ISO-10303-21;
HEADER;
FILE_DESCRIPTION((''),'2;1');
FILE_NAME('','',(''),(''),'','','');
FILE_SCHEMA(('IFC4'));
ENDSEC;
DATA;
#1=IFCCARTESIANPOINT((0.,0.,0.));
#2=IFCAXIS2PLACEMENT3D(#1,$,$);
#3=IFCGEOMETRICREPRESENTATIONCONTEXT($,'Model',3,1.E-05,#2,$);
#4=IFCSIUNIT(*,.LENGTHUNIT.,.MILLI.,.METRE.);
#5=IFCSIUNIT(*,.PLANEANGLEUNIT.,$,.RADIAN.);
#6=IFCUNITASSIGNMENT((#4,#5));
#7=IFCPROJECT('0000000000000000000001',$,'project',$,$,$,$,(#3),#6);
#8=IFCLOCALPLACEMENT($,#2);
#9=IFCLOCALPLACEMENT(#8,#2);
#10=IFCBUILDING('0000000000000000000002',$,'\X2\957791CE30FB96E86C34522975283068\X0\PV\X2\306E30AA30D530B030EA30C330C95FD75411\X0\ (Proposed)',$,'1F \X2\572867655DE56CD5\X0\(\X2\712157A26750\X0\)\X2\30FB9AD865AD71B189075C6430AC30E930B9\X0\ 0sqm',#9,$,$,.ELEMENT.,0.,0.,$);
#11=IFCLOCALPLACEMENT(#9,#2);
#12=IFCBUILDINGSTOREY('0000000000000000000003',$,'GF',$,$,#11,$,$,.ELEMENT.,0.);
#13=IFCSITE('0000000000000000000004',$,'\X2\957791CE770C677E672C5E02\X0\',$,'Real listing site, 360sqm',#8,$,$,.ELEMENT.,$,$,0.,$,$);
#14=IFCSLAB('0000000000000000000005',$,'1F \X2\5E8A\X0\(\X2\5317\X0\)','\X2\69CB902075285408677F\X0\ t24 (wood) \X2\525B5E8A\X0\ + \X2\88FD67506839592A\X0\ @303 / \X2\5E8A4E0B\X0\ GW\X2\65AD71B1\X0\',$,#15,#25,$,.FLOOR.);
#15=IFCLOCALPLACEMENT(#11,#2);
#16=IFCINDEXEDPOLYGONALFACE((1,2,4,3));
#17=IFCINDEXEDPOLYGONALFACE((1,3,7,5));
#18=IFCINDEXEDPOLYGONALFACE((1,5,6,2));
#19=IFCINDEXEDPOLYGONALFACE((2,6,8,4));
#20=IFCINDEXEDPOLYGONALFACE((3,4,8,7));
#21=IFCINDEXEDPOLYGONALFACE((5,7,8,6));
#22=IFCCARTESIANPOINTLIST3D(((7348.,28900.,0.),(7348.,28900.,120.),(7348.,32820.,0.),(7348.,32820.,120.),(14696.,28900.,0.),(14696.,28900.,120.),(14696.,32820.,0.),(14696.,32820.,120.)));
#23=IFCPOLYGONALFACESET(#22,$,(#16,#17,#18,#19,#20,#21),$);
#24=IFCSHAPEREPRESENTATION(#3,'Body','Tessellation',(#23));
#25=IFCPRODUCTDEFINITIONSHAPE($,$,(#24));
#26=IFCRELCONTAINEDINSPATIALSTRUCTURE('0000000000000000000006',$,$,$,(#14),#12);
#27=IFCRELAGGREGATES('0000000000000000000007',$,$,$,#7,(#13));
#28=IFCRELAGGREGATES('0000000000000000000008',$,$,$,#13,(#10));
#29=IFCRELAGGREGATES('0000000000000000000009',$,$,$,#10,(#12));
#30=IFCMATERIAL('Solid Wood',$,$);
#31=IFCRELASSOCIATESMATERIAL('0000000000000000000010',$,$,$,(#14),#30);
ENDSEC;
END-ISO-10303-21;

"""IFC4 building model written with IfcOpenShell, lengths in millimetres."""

from ifc_helpers import new_model, si_unit, frame, frame_2d, origin, place, context, project, spatial, rectangle, extrude, material, element, save


model = new_model("IFC4")

# Units and contexts
model_context = context("Model", 3, precision=1e-05, world=origin())
ifc_project = project(units=[si_unit("LENGTHUNIT", "METRE", prefix="MILLI"), si_unit("PLANEANGLEUNIT", "RADIAN")], contexts=[model_context])

# Site, building, storey
site_placement = place(None, origin())
site = spatial("IfcSite", under=ifc_project, at=site_placement, Name="長野県松本市", ObjectType="Real listing site, 360sqm", CompositionType="ELEMENT", RefElevation=0.0)
building_placement = place(site_placement, origin())
building = spatial("IfcBuilding", under=site, at=building_placement, Name="長野・雨水利用とPVのオフグリッド志向 (Proposed)", ObjectType="1F 在来工法(無垢材)・高断熱複層ガラス 0sqm", CompositionType="ELEMENT", ElevationOfRefHeight=0.0, ElevationOfTerrain=0.0)
storey_placement = place(building_placement, origin())
storey = spatial("IfcBuildingStorey", under=building, at=storey_placement, Name="GF", CompositionType="ELEMENT", Elevation=0.0)

# Slab
ifc_material_1 = material(Name="Solid Wood")
slab_1_placement = place(storey_placement, frame((3674.0, 14450.0, 0.0)))
element("IfcSlab", 1, at=slab_1_placement, inside=storey, material=ifc_material_1, Name="1F 床(北)", Description="構造用合板 t24 (wood) 剛床 + 製材根太 @303 / 床下 GW断熱", PredefinedType="FLOOR", context=model_context, shape_type="SweptSolid", body=[
    extrude(rectangle(XDim=7348.0, YDim=3920.0, at=frame_2d((3674.0, 1960.0))), frame((3674.0, 14450.0, 0.0)), (0.0, 0.0, 1.0), 120.0),
])

save(model, "model.ifc")
